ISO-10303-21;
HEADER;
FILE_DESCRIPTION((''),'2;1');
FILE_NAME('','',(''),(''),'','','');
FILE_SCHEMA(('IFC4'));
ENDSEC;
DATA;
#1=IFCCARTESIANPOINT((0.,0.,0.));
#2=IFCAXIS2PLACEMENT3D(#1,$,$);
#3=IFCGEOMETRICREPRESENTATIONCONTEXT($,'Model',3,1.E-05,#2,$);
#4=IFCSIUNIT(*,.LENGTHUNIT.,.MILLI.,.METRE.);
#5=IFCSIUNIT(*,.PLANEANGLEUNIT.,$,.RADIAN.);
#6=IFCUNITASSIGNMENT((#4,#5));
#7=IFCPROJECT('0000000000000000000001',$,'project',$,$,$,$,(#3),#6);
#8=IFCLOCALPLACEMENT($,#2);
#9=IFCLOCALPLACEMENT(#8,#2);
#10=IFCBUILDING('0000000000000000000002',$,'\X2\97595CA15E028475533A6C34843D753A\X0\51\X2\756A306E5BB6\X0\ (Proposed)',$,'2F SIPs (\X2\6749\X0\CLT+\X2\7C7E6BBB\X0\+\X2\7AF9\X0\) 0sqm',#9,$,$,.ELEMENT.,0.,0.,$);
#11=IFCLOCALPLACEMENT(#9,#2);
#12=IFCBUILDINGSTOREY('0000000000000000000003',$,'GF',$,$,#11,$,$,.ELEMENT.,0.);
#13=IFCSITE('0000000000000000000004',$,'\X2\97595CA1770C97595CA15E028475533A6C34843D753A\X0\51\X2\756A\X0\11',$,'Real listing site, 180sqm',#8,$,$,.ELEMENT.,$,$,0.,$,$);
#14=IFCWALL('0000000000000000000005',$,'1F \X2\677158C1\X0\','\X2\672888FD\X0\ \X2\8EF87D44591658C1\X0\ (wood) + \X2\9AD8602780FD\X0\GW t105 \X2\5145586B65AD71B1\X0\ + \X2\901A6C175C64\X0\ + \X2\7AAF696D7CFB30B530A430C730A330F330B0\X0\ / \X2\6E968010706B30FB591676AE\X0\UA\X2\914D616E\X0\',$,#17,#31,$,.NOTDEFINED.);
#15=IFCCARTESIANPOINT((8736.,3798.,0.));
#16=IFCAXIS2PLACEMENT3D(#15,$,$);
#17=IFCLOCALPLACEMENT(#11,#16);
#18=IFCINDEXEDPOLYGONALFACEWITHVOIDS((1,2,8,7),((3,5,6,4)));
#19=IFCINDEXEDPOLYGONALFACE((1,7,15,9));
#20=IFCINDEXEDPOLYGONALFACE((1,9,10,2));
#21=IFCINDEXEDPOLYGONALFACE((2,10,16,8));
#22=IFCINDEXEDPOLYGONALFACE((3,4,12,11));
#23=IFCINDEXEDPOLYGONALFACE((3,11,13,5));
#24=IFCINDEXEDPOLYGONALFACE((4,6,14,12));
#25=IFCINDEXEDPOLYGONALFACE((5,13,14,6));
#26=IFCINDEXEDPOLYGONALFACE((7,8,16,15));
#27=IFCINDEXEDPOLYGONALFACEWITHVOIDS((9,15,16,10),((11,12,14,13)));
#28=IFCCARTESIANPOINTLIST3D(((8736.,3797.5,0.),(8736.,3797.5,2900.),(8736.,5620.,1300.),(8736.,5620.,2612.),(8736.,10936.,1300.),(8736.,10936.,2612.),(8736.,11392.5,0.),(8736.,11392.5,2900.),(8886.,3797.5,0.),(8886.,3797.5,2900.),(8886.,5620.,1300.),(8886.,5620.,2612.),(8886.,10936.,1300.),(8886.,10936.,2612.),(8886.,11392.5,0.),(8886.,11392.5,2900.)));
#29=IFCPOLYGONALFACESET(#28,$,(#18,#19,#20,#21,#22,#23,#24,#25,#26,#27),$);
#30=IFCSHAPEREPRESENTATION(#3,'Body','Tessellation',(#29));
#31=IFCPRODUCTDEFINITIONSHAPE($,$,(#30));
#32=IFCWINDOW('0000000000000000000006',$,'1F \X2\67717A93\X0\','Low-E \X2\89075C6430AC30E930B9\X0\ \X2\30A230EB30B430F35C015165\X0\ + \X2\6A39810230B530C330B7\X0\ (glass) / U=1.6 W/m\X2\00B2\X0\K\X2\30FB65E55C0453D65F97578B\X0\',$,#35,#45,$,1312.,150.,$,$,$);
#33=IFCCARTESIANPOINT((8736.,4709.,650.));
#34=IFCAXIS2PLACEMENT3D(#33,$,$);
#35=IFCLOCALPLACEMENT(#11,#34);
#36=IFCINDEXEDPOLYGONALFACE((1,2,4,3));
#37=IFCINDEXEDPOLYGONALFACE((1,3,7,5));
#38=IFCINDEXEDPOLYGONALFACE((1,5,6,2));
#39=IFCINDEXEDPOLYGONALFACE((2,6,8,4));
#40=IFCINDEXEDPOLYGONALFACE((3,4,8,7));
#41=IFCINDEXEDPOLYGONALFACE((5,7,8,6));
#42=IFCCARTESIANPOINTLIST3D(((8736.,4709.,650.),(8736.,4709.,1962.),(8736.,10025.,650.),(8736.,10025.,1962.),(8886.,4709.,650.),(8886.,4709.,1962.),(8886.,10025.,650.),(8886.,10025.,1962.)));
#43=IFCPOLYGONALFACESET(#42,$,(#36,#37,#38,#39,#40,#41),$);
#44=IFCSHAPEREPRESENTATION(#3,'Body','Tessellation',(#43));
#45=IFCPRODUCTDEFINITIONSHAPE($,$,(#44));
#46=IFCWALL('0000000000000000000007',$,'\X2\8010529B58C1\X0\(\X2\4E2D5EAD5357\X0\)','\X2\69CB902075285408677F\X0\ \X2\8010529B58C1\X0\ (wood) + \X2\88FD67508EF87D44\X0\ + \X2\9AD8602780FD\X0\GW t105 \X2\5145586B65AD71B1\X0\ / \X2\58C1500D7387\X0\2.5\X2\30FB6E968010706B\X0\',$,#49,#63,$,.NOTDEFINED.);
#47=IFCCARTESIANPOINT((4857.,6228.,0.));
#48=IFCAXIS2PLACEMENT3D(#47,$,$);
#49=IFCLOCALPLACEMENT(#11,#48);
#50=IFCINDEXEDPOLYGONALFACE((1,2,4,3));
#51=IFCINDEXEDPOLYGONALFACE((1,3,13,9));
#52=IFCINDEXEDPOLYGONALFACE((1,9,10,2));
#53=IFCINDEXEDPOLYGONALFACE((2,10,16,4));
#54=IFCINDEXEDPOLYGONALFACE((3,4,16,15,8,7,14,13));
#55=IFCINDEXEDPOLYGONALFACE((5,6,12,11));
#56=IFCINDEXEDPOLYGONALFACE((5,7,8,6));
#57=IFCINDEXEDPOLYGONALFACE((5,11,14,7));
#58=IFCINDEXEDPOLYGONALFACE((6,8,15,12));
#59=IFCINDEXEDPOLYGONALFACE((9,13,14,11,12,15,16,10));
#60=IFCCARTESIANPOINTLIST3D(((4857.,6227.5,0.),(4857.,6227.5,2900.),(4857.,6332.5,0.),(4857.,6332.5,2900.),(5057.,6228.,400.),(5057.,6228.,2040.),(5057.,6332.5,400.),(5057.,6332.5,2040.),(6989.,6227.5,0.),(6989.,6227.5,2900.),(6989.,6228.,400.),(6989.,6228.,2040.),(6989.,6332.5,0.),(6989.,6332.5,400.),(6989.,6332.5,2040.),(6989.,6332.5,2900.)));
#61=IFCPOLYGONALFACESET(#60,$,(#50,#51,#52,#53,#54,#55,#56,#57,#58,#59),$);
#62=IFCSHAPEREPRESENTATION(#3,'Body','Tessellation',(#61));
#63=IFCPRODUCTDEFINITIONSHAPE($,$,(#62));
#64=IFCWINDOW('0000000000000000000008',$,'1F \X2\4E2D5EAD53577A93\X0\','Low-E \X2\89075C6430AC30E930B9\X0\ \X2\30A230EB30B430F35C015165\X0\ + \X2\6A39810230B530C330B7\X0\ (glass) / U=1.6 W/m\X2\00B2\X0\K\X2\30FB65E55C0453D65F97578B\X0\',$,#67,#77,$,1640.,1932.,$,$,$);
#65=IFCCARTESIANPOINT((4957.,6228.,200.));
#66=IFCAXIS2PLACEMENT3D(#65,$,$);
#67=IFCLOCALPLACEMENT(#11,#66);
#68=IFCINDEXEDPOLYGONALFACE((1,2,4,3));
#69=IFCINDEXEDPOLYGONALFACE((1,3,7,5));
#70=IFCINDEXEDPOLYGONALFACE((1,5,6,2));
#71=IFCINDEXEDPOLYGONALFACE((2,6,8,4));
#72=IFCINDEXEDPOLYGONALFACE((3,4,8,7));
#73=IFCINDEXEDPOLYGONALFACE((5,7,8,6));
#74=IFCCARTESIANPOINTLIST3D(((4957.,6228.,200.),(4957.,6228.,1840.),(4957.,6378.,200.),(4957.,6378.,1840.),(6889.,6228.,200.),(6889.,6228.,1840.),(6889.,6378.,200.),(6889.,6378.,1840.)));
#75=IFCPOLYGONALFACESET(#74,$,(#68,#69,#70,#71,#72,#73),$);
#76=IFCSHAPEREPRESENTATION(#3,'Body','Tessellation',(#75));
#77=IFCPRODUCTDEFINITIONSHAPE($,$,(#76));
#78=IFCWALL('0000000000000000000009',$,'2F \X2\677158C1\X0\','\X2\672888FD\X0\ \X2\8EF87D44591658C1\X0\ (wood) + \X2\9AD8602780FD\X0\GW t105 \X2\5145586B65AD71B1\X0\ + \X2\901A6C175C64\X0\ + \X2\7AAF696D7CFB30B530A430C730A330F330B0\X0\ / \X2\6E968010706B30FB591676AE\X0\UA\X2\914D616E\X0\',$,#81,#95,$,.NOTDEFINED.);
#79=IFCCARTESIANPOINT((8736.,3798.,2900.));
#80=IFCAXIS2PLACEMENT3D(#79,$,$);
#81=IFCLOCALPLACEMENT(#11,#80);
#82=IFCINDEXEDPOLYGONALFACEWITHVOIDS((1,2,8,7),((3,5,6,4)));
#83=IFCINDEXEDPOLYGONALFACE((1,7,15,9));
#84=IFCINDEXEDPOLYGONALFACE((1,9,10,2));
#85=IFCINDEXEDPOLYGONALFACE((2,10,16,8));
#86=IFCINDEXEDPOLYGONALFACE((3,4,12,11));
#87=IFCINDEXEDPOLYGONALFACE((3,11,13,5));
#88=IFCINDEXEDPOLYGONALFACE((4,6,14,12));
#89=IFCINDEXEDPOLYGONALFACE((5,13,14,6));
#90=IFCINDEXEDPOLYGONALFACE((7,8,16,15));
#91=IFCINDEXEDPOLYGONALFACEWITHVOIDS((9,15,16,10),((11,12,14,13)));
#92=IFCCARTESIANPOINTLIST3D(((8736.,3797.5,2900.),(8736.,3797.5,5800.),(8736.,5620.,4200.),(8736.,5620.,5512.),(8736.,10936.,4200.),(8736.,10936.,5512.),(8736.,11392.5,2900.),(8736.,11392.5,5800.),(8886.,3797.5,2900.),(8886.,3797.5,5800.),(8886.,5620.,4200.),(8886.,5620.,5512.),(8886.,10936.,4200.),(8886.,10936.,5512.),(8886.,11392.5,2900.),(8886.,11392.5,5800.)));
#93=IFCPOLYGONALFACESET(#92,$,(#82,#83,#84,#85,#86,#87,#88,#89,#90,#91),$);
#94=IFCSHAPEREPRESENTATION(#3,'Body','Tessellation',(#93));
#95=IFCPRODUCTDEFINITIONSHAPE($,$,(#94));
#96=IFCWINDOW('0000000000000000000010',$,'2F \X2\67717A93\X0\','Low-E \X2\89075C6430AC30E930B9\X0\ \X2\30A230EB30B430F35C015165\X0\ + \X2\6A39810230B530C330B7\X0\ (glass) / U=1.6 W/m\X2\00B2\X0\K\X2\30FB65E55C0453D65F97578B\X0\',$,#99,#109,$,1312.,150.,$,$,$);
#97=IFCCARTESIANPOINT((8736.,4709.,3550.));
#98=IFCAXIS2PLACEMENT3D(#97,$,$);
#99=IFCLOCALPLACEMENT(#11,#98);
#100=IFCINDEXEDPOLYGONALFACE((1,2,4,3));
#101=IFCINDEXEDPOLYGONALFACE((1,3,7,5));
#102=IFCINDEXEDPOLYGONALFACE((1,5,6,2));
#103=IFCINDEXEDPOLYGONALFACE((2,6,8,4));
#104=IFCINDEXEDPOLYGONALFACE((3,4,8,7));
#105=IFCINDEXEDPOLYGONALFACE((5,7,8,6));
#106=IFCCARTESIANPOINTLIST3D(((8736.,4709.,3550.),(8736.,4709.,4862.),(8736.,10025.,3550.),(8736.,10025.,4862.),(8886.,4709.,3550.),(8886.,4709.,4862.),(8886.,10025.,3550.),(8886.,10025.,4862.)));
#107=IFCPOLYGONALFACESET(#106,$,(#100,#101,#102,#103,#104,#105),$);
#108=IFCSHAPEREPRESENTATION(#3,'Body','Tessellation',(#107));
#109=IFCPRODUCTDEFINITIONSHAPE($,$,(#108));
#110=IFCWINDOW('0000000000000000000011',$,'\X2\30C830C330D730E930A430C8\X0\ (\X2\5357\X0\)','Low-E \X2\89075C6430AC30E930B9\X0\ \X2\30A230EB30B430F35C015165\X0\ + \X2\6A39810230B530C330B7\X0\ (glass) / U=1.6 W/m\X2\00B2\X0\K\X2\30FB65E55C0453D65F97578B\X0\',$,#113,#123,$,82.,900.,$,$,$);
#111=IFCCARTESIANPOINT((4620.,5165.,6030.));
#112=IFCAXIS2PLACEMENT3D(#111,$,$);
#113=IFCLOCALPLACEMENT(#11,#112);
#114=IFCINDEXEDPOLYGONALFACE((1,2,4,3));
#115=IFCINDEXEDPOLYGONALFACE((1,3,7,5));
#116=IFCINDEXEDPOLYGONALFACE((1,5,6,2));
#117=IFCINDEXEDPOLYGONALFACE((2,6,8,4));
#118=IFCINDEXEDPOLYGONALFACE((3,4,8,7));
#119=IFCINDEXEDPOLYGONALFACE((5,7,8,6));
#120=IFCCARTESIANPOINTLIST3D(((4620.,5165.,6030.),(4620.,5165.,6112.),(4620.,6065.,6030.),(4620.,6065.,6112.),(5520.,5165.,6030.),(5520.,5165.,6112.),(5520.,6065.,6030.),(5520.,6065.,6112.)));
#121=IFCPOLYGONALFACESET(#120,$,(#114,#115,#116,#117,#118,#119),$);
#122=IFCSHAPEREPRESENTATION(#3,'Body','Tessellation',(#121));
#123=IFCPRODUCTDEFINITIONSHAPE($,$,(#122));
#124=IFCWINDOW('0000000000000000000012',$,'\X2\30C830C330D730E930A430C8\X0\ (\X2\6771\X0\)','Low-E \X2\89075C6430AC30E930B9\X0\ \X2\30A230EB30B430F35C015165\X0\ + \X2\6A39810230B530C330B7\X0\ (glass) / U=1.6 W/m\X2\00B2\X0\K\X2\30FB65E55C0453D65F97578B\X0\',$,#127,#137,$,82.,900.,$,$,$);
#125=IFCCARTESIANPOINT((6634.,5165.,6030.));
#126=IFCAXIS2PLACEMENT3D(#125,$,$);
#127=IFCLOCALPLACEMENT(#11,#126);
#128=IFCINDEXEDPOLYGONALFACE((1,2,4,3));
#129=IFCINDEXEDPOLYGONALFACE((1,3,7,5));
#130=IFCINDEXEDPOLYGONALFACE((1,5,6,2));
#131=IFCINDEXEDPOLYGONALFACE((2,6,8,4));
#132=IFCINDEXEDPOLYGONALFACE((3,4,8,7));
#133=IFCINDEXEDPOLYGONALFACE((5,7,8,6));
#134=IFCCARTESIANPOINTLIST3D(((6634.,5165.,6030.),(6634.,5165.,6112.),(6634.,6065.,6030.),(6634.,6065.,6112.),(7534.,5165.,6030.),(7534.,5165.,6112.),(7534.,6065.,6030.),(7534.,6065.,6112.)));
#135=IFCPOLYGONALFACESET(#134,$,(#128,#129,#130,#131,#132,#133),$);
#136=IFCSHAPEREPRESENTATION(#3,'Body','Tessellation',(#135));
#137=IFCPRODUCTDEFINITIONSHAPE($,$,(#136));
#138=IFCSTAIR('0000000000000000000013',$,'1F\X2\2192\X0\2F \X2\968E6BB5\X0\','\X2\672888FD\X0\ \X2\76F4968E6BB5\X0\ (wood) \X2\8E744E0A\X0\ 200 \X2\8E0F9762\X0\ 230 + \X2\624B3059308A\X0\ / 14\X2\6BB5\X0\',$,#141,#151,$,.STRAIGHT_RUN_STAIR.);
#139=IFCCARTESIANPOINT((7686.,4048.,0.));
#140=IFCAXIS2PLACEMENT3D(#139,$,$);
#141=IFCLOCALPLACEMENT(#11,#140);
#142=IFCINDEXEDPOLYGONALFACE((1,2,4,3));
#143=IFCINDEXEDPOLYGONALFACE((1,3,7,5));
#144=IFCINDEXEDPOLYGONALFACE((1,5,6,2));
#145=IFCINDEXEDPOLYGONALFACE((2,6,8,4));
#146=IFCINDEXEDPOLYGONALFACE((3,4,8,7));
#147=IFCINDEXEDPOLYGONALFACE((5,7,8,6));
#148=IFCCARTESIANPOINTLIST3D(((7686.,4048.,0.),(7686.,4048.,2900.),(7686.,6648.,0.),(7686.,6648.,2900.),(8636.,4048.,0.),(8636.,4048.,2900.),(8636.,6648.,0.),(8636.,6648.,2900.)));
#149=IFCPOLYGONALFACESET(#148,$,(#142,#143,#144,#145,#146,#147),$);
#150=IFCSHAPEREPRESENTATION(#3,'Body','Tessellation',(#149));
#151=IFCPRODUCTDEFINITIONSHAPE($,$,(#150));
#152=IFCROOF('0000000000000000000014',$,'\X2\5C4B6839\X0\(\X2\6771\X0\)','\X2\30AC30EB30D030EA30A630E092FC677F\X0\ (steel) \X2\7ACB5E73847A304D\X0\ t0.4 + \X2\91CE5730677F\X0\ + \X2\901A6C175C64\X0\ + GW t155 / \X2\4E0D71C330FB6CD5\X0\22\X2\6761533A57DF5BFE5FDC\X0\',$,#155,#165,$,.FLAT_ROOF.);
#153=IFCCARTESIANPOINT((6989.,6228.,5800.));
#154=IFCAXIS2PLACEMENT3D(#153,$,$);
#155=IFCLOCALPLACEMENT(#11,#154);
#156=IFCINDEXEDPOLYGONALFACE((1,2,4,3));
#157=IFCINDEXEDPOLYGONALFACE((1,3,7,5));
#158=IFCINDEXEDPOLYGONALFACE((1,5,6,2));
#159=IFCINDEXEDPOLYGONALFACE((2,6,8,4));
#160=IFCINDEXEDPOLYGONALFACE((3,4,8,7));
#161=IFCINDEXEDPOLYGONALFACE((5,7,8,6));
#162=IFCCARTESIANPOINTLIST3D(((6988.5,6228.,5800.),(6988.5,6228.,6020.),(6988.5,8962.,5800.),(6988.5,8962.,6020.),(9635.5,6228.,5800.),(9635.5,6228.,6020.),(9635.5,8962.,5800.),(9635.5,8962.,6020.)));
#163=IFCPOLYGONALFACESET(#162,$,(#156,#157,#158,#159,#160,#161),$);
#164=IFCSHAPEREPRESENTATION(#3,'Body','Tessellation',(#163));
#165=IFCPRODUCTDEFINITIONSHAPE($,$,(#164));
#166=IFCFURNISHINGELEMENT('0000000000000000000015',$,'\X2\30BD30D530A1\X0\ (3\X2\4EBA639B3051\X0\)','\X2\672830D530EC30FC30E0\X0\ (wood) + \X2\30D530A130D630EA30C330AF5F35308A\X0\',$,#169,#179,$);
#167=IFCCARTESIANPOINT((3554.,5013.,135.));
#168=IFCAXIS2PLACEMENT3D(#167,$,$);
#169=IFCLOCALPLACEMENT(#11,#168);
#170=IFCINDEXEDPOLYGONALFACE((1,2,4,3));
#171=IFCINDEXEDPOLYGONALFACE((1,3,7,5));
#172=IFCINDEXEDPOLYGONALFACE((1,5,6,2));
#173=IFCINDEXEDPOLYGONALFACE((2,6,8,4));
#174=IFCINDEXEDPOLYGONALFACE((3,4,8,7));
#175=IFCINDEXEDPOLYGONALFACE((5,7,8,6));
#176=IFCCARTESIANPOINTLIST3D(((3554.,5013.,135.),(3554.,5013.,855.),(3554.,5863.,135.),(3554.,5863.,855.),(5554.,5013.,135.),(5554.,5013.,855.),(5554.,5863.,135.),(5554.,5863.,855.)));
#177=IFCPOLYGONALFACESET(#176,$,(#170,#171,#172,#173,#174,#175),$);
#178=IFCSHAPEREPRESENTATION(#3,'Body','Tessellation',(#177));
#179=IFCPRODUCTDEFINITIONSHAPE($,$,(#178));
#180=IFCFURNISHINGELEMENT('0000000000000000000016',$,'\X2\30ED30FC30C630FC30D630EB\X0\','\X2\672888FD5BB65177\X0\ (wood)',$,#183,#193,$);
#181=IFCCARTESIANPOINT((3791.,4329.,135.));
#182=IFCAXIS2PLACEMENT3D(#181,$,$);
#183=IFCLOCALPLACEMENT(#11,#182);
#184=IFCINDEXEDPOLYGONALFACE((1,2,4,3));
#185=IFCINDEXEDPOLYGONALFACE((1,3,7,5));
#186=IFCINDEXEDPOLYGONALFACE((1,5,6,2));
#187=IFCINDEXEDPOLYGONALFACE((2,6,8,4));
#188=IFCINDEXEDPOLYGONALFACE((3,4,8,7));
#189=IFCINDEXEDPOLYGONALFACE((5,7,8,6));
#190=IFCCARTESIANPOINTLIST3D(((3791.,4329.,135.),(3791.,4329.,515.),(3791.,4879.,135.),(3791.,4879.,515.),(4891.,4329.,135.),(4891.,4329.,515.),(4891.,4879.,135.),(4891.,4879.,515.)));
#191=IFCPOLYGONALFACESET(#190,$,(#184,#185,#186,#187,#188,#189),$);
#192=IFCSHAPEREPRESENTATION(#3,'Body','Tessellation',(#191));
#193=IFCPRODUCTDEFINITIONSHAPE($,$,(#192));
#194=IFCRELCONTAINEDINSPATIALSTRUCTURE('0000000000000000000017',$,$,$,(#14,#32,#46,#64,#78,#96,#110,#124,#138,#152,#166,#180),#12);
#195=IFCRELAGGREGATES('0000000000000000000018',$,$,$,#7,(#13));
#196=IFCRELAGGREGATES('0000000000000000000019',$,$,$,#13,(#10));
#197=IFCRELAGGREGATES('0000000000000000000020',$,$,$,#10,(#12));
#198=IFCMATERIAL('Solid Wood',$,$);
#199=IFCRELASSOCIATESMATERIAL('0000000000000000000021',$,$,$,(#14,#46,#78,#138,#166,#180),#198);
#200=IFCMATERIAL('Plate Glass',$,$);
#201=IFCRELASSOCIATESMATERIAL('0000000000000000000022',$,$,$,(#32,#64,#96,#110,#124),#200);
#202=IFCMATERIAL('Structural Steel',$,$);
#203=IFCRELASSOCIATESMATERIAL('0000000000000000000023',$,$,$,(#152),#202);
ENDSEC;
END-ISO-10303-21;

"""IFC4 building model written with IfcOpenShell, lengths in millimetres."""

from ifc_helpers import new_model, si_unit, frame, frame_2d, origin, place, context, project, spatial, rectangle, extrude, material, element, fill, save


model = new_model("IFC4")

# Units and contexts
model_context = context("Model", 3, precision=1e-05, world=origin())
ifc_project = project(units=[si_unit("LENGTHUNIT", "METRE", prefix="MILLI"), si_unit("PLANEANGLEUNIT", "RADIAN")], contexts=[model_context])

# Site, building, storey
site_placement = place(None, origin())
site = spatial("IfcSite", under=ifc_project, at=site_placement, Name="静岡県静岡市葵区水落町51番11", ObjectType="Real listing site, 180sqm", CompositionType="ELEMENT", RefElevation=0.0)
building_placement = place(site_placement, origin())
building = spatial("IfcBuilding", under=site, at=building_placement, Name="静岡市葵区水落町51番の家 (Proposed)", ObjectType="2F SIPs (杉CLT+籾殻+竹) 0sqm", CompositionType="ELEMENT", ElevationOfRefHeight=0.0, ElevationOfTerrain=0.0)
storey_placement = place(building_placement, origin())
storey = spatial("IfcBuildingStorey", under=building, at=storey_placement, Name="GF", CompositionType="ELEMENT", Elevation=0.0)

# Shared definitions
ifc_material_1 = material(Name="Solid Wood")

# Walls, openings, windows
wall_1_placement = place(storey_placement, frame((8736.0, 3798.0, 0.0)))
wall_1 = element("IfcWall", 1, at=wall_1_placement, inside=storey, material=ifc_material_1, Name="1F 東壁", Description="木製 軸組外壁 (wood) + 高性能GW t105 充填断熱 + 通気層 + 窯業系サイディング / 準耐火・外皮UA配慮", PredefinedType="NOTDEFINED", context=model_context, shape_type="SweptSolid", body=[
    extrude(rectangle(XDim=150.0, YDim=7595.0, at=frame_2d((75.0, 3797.0))), frame((8736.0, 3798.0, 0.0)), (0.0, 0.0, 1.0), 2900.0),
])
opening_1_placement = place(storey_placement, frame((8736.0, 4709.0, 650.0)))
opening_1 = element("IfcOpeningElement", 2, at=opening_1_placement, cuts=wall_1, PredefinedType="NOTDEFINED", context=model_context, shape_type="SweptSolid", body=[
    extrude(rectangle(XDim=150.0, YDim=5316.0, at=frame_2d((75.0, 2658.0))), frame((8736.0, 4709.0, 650.0)), (0.0, 0.0, 1.0), 1312.0),
])
ifc_material_2 = material(Name="Plate Glass")
window_1_placement = place(storey_placement, frame((8736.0, 4709.0, 650.0)))
window_1 = element("IfcWindow", 3, at=window_1_placement, inside=storey, material=ifc_material_2, Name="1F 東窓", Description="Low-E 複層ガラス アルゴン封入 + 樹脂サッシ (glass) / U=1.6 W/m²K・日射取得型", OverallHeight=1312.0, OverallWidth=150.0, context=model_context, shape_type="SweptSolid", body=[
    extrude(rectangle(XDim=150.0, YDim=5316.0, at=frame_2d((75.0, 2658.0))), frame((8736.0, 4709.0, 650.0)), (0.0, 0.0, 1.0), 1312.0),
])
fill(opening_1, window_1)
wall_2_placement = place(storey_placement, frame((4857.0, 6228.0, 0.0)))
wall_2 = element("IfcWall", 4, at=wall_2_placement, inside=storey, material=ifc_material_1, Name="耐力壁(中庭南)", Description="構造用合板 耐力壁 (wood) + 製材軸組 + 高性能GW t105 充填断熱 / 壁倍率2.5・準耐火", PredefinedType="NOTDEFINED", context=model_context, shape_type="SweptSolid", body=[
    extrude(rectangle(XDim=2132.0, YDim=105.0, at=frame_2d((1066.0, 52.0))), frame((4857.0, 6228.0, 0.0)), (0.0, 0.0, 1.0), 2900.0),
])
opening_2_placement = place(storey_placement, frame((4957.0, 6228.0, 200.0)))
opening_2 = element("IfcOpeningElement", 5, at=opening_2_placement, cuts=wall_2, PredefinedType="NOTDEFINED", context=model_context, shape_type="SweptSolid", body=[
    extrude(rectangle(XDim=1932.0, YDim=150.0, at=frame_2d((966.0, 75.0))), frame((4957.0, 6228.0, 200.0)), (0.0, 0.0, 1.0), 1640.0),
])
window_2_placement = place(storey_placement, frame((4957.0, 6228.0, 200.0)))
window_2 = element("IfcWindow", 6, at=window_2_placement, inside=storey, material=ifc_material_2, Name="1F 中庭南窓", Description="Low-E 複層ガラス アルゴン封入 + 樹脂サッシ (glass) / U=1.6 W/m²K・日射取得型", OverallHeight=1640.0, OverallWidth=1932.0, context=model_context, shape_type="SweptSolid", body=[
    extrude(rectangle(XDim=1932.0, YDim=150.0, at=frame_2d((966.0, 75.0))), frame((4957.0, 6228.0, 200.0)), (0.0, 0.0, 1.0), 1640.0),
])
fill(opening_2, window_2)

# Wall, opening, window
wall_3_placement = place(storey_placement, frame((8736.0, 3798.0, 2900.0)))
wall_3 = element("IfcWall", 7, at=wall_3_placement, inside=storey, material=ifc_material_1, Name="2F 東壁", Description="木製 軸組外壁 (wood) + 高性能GW t105 充填断熱 + 通気層 + 窯業系サイディング / 準耐火・外皮UA配慮", PredefinedType="NOTDEFINED", context=model_context, shape_type="SweptSolid", body=[
    extrude(rectangle(XDim=150.0, YDim=7595.0, at=frame_2d((75.0, 3797.0))), frame((8736.0, 3798.0, 2900.0)), (0.0, 0.0, 1.0), 2900.0),
])
opening_3_placement = place(storey_placement, frame((8736.0, 4709.0, 3550.0)))
opening_3 = element("IfcOpeningElement", 8, at=opening_3_placement, cuts=wall_3, PredefinedType="NOTDEFINED", context=model_context, shape_type="SweptSolid", body=[
    extrude(rectangle(XDim=150.0, YDim=5316.0, at=frame_2d((75.0, 2658.0))), frame((8736.0, 4709.0, 3550.0)), (0.0, 0.0, 1.0), 1312.0),
])
window_3_placement = place(storey_placement, frame((8736.0, 4709.0, 3550.0)))
window_3 = element("IfcWindow", 9, at=window_3_placement, inside=storey, material=ifc_material_2, Name="2F 東窓", Description="Low-E 複層ガラス アルゴン封入 + 樹脂サッシ (glass) / U=1.6 W/m²K・日射取得型", OverallHeight=1312.0, OverallWidth=150.0, context=model_context, shape_type="SweptSolid", body=[
    extrude(rectangle(XDim=150.0, YDim=5316.0, at=frame_2d((75.0, 2658.0))), frame((8736.0, 4709.0, 3550.0)), (0.0, 0.0, 1.0), 1312.0),
])
fill(opening_3, window_3)

# Windows
window_4_placement = place(storey_placement, frame((4620.0, 5165.0, 6030.0)))
element("IfcWindow", 10, at=window_4_placement, inside=storey, material=ifc_material_2, Name="トップライト (南)", Description="Low-E 複層ガラス アルゴン封入 + 樹脂サッシ (glass) / U=1.6 W/m²K・日射取得型", OverallHeight=82.0, OverallWidth=900.0, context=model_context, shape_type="SweptSolid", body=[
    extrude(rectangle(XDim=900.0, YDim=900.0, at=frame_2d((450.0, 450.0))), frame((4620.0, 5165.0, 6030.0)), (0.0, 0.0, 1.0), 82.0),
])
window_5_placement = place(storey_placement, frame((6634.0, 5165.0, 6030.0)))
element("IfcWindow", 11, at=window_5_placement, inside=storey, material=ifc_material_2, Name="トップライト (東)", Description="Low-E 複層ガラス アルゴン封入 + 樹脂サッシ (glass) / U=1.6 W/m²K・日射取得型", OverallHeight=82.0, OverallWidth=900.0, context=model_context, shape_type="SweptSolid", body=[
    extrude(rectangle(XDim=900.0, YDim=900.0, at=frame_2d((450.0, 450.0))), frame((6634.0, 5165.0, 6030.0)), (0.0, 0.0, 1.0), 82.0),
])

# Stair
stair_placement = place(storey_placement, frame((7686.0, 4048.0, 0.0)))
element("IfcStair", 12, at=stair_placement, inside=storey, material=ifc_material_1, Name="1F→2F 階段", Description="木製 直階段 (wood) 蹴上 200 踏面 230 + 手すり / 14段", PredefinedType="STRAIGHT_RUN_STAIR", context=model_context, shape_type="SweptSolid", body=[
    extrude(rectangle(XDim=950.0, YDim=2600.0, at=frame_2d((475.0, 1300.0))), frame((7686.0, 4048.0, 0.0)), (0.0, 0.0, 1.0), 2900.0),
])

# Roof
ifc_material_3 = material(Name="Structural Steel")
roof_placement = place(storey_placement, frame((6989.0, 6228.0, 5800.0)))
element("IfcRoof", 13, at=roof_placement, inside=storey, material=ifc_material_3, Name="屋根(東)", Description="ガルバリウム鋼板 (steel) 立平葺き t0.4 + 野地板 + 通気層 + GW t155 / 不燃・法22条区域対応", PredefinedType="FLAT_ROOF", context=model_context, shape_type="SweptSolid", body=[
    extrude(rectangle(XDim=2647.0, YDim=2734.0, at=frame_2d((1323.0, 1367.0))), frame((6989.0, 6228.0, 5800.0)), (0.0, 0.0, 1.0), 220.0),
])

# Furnishing elements
furnishing_1_placement = place(storey_placement, frame((3554.0, 5013.0, 135.0)))
element("IfcFurnishingElement", 14, at=furnishing_1_placement, inside=storey, material=ifc_material_1, Name="ソファ (3人掛け)", Description="木フレーム (wood) + ファブリック張り", context=model_context, shape_type="SweptSolid", body=[
    extrude(rectangle(XDim=2000.0, YDim=850.0, at=frame_2d((1000.0, 425.0))), frame((3554.0, 5013.0, 135.0)), (0.0, 0.0, 1.0), 720.0),
])
furnishing_2_placement = place(storey_placement, frame((3791.0, 4329.0, 135.0)))
element("IfcFurnishingElement", 15, at=furnishing_2_placement, inside=storey, material=ifc_material_1, Name="ローテーブル", Description="木製家具 (wood)", context=model_context, shape_type="SweptSolid", body=[
    extrude(rectangle(XDim=1100.0, YDim=550.0, at=frame_2d((550.0, 275.0))), frame((3791.0, 4329.0, 135.0)), (0.0, 0.0, 1.0), 380.0),
])

save(model, "model.ifc")
